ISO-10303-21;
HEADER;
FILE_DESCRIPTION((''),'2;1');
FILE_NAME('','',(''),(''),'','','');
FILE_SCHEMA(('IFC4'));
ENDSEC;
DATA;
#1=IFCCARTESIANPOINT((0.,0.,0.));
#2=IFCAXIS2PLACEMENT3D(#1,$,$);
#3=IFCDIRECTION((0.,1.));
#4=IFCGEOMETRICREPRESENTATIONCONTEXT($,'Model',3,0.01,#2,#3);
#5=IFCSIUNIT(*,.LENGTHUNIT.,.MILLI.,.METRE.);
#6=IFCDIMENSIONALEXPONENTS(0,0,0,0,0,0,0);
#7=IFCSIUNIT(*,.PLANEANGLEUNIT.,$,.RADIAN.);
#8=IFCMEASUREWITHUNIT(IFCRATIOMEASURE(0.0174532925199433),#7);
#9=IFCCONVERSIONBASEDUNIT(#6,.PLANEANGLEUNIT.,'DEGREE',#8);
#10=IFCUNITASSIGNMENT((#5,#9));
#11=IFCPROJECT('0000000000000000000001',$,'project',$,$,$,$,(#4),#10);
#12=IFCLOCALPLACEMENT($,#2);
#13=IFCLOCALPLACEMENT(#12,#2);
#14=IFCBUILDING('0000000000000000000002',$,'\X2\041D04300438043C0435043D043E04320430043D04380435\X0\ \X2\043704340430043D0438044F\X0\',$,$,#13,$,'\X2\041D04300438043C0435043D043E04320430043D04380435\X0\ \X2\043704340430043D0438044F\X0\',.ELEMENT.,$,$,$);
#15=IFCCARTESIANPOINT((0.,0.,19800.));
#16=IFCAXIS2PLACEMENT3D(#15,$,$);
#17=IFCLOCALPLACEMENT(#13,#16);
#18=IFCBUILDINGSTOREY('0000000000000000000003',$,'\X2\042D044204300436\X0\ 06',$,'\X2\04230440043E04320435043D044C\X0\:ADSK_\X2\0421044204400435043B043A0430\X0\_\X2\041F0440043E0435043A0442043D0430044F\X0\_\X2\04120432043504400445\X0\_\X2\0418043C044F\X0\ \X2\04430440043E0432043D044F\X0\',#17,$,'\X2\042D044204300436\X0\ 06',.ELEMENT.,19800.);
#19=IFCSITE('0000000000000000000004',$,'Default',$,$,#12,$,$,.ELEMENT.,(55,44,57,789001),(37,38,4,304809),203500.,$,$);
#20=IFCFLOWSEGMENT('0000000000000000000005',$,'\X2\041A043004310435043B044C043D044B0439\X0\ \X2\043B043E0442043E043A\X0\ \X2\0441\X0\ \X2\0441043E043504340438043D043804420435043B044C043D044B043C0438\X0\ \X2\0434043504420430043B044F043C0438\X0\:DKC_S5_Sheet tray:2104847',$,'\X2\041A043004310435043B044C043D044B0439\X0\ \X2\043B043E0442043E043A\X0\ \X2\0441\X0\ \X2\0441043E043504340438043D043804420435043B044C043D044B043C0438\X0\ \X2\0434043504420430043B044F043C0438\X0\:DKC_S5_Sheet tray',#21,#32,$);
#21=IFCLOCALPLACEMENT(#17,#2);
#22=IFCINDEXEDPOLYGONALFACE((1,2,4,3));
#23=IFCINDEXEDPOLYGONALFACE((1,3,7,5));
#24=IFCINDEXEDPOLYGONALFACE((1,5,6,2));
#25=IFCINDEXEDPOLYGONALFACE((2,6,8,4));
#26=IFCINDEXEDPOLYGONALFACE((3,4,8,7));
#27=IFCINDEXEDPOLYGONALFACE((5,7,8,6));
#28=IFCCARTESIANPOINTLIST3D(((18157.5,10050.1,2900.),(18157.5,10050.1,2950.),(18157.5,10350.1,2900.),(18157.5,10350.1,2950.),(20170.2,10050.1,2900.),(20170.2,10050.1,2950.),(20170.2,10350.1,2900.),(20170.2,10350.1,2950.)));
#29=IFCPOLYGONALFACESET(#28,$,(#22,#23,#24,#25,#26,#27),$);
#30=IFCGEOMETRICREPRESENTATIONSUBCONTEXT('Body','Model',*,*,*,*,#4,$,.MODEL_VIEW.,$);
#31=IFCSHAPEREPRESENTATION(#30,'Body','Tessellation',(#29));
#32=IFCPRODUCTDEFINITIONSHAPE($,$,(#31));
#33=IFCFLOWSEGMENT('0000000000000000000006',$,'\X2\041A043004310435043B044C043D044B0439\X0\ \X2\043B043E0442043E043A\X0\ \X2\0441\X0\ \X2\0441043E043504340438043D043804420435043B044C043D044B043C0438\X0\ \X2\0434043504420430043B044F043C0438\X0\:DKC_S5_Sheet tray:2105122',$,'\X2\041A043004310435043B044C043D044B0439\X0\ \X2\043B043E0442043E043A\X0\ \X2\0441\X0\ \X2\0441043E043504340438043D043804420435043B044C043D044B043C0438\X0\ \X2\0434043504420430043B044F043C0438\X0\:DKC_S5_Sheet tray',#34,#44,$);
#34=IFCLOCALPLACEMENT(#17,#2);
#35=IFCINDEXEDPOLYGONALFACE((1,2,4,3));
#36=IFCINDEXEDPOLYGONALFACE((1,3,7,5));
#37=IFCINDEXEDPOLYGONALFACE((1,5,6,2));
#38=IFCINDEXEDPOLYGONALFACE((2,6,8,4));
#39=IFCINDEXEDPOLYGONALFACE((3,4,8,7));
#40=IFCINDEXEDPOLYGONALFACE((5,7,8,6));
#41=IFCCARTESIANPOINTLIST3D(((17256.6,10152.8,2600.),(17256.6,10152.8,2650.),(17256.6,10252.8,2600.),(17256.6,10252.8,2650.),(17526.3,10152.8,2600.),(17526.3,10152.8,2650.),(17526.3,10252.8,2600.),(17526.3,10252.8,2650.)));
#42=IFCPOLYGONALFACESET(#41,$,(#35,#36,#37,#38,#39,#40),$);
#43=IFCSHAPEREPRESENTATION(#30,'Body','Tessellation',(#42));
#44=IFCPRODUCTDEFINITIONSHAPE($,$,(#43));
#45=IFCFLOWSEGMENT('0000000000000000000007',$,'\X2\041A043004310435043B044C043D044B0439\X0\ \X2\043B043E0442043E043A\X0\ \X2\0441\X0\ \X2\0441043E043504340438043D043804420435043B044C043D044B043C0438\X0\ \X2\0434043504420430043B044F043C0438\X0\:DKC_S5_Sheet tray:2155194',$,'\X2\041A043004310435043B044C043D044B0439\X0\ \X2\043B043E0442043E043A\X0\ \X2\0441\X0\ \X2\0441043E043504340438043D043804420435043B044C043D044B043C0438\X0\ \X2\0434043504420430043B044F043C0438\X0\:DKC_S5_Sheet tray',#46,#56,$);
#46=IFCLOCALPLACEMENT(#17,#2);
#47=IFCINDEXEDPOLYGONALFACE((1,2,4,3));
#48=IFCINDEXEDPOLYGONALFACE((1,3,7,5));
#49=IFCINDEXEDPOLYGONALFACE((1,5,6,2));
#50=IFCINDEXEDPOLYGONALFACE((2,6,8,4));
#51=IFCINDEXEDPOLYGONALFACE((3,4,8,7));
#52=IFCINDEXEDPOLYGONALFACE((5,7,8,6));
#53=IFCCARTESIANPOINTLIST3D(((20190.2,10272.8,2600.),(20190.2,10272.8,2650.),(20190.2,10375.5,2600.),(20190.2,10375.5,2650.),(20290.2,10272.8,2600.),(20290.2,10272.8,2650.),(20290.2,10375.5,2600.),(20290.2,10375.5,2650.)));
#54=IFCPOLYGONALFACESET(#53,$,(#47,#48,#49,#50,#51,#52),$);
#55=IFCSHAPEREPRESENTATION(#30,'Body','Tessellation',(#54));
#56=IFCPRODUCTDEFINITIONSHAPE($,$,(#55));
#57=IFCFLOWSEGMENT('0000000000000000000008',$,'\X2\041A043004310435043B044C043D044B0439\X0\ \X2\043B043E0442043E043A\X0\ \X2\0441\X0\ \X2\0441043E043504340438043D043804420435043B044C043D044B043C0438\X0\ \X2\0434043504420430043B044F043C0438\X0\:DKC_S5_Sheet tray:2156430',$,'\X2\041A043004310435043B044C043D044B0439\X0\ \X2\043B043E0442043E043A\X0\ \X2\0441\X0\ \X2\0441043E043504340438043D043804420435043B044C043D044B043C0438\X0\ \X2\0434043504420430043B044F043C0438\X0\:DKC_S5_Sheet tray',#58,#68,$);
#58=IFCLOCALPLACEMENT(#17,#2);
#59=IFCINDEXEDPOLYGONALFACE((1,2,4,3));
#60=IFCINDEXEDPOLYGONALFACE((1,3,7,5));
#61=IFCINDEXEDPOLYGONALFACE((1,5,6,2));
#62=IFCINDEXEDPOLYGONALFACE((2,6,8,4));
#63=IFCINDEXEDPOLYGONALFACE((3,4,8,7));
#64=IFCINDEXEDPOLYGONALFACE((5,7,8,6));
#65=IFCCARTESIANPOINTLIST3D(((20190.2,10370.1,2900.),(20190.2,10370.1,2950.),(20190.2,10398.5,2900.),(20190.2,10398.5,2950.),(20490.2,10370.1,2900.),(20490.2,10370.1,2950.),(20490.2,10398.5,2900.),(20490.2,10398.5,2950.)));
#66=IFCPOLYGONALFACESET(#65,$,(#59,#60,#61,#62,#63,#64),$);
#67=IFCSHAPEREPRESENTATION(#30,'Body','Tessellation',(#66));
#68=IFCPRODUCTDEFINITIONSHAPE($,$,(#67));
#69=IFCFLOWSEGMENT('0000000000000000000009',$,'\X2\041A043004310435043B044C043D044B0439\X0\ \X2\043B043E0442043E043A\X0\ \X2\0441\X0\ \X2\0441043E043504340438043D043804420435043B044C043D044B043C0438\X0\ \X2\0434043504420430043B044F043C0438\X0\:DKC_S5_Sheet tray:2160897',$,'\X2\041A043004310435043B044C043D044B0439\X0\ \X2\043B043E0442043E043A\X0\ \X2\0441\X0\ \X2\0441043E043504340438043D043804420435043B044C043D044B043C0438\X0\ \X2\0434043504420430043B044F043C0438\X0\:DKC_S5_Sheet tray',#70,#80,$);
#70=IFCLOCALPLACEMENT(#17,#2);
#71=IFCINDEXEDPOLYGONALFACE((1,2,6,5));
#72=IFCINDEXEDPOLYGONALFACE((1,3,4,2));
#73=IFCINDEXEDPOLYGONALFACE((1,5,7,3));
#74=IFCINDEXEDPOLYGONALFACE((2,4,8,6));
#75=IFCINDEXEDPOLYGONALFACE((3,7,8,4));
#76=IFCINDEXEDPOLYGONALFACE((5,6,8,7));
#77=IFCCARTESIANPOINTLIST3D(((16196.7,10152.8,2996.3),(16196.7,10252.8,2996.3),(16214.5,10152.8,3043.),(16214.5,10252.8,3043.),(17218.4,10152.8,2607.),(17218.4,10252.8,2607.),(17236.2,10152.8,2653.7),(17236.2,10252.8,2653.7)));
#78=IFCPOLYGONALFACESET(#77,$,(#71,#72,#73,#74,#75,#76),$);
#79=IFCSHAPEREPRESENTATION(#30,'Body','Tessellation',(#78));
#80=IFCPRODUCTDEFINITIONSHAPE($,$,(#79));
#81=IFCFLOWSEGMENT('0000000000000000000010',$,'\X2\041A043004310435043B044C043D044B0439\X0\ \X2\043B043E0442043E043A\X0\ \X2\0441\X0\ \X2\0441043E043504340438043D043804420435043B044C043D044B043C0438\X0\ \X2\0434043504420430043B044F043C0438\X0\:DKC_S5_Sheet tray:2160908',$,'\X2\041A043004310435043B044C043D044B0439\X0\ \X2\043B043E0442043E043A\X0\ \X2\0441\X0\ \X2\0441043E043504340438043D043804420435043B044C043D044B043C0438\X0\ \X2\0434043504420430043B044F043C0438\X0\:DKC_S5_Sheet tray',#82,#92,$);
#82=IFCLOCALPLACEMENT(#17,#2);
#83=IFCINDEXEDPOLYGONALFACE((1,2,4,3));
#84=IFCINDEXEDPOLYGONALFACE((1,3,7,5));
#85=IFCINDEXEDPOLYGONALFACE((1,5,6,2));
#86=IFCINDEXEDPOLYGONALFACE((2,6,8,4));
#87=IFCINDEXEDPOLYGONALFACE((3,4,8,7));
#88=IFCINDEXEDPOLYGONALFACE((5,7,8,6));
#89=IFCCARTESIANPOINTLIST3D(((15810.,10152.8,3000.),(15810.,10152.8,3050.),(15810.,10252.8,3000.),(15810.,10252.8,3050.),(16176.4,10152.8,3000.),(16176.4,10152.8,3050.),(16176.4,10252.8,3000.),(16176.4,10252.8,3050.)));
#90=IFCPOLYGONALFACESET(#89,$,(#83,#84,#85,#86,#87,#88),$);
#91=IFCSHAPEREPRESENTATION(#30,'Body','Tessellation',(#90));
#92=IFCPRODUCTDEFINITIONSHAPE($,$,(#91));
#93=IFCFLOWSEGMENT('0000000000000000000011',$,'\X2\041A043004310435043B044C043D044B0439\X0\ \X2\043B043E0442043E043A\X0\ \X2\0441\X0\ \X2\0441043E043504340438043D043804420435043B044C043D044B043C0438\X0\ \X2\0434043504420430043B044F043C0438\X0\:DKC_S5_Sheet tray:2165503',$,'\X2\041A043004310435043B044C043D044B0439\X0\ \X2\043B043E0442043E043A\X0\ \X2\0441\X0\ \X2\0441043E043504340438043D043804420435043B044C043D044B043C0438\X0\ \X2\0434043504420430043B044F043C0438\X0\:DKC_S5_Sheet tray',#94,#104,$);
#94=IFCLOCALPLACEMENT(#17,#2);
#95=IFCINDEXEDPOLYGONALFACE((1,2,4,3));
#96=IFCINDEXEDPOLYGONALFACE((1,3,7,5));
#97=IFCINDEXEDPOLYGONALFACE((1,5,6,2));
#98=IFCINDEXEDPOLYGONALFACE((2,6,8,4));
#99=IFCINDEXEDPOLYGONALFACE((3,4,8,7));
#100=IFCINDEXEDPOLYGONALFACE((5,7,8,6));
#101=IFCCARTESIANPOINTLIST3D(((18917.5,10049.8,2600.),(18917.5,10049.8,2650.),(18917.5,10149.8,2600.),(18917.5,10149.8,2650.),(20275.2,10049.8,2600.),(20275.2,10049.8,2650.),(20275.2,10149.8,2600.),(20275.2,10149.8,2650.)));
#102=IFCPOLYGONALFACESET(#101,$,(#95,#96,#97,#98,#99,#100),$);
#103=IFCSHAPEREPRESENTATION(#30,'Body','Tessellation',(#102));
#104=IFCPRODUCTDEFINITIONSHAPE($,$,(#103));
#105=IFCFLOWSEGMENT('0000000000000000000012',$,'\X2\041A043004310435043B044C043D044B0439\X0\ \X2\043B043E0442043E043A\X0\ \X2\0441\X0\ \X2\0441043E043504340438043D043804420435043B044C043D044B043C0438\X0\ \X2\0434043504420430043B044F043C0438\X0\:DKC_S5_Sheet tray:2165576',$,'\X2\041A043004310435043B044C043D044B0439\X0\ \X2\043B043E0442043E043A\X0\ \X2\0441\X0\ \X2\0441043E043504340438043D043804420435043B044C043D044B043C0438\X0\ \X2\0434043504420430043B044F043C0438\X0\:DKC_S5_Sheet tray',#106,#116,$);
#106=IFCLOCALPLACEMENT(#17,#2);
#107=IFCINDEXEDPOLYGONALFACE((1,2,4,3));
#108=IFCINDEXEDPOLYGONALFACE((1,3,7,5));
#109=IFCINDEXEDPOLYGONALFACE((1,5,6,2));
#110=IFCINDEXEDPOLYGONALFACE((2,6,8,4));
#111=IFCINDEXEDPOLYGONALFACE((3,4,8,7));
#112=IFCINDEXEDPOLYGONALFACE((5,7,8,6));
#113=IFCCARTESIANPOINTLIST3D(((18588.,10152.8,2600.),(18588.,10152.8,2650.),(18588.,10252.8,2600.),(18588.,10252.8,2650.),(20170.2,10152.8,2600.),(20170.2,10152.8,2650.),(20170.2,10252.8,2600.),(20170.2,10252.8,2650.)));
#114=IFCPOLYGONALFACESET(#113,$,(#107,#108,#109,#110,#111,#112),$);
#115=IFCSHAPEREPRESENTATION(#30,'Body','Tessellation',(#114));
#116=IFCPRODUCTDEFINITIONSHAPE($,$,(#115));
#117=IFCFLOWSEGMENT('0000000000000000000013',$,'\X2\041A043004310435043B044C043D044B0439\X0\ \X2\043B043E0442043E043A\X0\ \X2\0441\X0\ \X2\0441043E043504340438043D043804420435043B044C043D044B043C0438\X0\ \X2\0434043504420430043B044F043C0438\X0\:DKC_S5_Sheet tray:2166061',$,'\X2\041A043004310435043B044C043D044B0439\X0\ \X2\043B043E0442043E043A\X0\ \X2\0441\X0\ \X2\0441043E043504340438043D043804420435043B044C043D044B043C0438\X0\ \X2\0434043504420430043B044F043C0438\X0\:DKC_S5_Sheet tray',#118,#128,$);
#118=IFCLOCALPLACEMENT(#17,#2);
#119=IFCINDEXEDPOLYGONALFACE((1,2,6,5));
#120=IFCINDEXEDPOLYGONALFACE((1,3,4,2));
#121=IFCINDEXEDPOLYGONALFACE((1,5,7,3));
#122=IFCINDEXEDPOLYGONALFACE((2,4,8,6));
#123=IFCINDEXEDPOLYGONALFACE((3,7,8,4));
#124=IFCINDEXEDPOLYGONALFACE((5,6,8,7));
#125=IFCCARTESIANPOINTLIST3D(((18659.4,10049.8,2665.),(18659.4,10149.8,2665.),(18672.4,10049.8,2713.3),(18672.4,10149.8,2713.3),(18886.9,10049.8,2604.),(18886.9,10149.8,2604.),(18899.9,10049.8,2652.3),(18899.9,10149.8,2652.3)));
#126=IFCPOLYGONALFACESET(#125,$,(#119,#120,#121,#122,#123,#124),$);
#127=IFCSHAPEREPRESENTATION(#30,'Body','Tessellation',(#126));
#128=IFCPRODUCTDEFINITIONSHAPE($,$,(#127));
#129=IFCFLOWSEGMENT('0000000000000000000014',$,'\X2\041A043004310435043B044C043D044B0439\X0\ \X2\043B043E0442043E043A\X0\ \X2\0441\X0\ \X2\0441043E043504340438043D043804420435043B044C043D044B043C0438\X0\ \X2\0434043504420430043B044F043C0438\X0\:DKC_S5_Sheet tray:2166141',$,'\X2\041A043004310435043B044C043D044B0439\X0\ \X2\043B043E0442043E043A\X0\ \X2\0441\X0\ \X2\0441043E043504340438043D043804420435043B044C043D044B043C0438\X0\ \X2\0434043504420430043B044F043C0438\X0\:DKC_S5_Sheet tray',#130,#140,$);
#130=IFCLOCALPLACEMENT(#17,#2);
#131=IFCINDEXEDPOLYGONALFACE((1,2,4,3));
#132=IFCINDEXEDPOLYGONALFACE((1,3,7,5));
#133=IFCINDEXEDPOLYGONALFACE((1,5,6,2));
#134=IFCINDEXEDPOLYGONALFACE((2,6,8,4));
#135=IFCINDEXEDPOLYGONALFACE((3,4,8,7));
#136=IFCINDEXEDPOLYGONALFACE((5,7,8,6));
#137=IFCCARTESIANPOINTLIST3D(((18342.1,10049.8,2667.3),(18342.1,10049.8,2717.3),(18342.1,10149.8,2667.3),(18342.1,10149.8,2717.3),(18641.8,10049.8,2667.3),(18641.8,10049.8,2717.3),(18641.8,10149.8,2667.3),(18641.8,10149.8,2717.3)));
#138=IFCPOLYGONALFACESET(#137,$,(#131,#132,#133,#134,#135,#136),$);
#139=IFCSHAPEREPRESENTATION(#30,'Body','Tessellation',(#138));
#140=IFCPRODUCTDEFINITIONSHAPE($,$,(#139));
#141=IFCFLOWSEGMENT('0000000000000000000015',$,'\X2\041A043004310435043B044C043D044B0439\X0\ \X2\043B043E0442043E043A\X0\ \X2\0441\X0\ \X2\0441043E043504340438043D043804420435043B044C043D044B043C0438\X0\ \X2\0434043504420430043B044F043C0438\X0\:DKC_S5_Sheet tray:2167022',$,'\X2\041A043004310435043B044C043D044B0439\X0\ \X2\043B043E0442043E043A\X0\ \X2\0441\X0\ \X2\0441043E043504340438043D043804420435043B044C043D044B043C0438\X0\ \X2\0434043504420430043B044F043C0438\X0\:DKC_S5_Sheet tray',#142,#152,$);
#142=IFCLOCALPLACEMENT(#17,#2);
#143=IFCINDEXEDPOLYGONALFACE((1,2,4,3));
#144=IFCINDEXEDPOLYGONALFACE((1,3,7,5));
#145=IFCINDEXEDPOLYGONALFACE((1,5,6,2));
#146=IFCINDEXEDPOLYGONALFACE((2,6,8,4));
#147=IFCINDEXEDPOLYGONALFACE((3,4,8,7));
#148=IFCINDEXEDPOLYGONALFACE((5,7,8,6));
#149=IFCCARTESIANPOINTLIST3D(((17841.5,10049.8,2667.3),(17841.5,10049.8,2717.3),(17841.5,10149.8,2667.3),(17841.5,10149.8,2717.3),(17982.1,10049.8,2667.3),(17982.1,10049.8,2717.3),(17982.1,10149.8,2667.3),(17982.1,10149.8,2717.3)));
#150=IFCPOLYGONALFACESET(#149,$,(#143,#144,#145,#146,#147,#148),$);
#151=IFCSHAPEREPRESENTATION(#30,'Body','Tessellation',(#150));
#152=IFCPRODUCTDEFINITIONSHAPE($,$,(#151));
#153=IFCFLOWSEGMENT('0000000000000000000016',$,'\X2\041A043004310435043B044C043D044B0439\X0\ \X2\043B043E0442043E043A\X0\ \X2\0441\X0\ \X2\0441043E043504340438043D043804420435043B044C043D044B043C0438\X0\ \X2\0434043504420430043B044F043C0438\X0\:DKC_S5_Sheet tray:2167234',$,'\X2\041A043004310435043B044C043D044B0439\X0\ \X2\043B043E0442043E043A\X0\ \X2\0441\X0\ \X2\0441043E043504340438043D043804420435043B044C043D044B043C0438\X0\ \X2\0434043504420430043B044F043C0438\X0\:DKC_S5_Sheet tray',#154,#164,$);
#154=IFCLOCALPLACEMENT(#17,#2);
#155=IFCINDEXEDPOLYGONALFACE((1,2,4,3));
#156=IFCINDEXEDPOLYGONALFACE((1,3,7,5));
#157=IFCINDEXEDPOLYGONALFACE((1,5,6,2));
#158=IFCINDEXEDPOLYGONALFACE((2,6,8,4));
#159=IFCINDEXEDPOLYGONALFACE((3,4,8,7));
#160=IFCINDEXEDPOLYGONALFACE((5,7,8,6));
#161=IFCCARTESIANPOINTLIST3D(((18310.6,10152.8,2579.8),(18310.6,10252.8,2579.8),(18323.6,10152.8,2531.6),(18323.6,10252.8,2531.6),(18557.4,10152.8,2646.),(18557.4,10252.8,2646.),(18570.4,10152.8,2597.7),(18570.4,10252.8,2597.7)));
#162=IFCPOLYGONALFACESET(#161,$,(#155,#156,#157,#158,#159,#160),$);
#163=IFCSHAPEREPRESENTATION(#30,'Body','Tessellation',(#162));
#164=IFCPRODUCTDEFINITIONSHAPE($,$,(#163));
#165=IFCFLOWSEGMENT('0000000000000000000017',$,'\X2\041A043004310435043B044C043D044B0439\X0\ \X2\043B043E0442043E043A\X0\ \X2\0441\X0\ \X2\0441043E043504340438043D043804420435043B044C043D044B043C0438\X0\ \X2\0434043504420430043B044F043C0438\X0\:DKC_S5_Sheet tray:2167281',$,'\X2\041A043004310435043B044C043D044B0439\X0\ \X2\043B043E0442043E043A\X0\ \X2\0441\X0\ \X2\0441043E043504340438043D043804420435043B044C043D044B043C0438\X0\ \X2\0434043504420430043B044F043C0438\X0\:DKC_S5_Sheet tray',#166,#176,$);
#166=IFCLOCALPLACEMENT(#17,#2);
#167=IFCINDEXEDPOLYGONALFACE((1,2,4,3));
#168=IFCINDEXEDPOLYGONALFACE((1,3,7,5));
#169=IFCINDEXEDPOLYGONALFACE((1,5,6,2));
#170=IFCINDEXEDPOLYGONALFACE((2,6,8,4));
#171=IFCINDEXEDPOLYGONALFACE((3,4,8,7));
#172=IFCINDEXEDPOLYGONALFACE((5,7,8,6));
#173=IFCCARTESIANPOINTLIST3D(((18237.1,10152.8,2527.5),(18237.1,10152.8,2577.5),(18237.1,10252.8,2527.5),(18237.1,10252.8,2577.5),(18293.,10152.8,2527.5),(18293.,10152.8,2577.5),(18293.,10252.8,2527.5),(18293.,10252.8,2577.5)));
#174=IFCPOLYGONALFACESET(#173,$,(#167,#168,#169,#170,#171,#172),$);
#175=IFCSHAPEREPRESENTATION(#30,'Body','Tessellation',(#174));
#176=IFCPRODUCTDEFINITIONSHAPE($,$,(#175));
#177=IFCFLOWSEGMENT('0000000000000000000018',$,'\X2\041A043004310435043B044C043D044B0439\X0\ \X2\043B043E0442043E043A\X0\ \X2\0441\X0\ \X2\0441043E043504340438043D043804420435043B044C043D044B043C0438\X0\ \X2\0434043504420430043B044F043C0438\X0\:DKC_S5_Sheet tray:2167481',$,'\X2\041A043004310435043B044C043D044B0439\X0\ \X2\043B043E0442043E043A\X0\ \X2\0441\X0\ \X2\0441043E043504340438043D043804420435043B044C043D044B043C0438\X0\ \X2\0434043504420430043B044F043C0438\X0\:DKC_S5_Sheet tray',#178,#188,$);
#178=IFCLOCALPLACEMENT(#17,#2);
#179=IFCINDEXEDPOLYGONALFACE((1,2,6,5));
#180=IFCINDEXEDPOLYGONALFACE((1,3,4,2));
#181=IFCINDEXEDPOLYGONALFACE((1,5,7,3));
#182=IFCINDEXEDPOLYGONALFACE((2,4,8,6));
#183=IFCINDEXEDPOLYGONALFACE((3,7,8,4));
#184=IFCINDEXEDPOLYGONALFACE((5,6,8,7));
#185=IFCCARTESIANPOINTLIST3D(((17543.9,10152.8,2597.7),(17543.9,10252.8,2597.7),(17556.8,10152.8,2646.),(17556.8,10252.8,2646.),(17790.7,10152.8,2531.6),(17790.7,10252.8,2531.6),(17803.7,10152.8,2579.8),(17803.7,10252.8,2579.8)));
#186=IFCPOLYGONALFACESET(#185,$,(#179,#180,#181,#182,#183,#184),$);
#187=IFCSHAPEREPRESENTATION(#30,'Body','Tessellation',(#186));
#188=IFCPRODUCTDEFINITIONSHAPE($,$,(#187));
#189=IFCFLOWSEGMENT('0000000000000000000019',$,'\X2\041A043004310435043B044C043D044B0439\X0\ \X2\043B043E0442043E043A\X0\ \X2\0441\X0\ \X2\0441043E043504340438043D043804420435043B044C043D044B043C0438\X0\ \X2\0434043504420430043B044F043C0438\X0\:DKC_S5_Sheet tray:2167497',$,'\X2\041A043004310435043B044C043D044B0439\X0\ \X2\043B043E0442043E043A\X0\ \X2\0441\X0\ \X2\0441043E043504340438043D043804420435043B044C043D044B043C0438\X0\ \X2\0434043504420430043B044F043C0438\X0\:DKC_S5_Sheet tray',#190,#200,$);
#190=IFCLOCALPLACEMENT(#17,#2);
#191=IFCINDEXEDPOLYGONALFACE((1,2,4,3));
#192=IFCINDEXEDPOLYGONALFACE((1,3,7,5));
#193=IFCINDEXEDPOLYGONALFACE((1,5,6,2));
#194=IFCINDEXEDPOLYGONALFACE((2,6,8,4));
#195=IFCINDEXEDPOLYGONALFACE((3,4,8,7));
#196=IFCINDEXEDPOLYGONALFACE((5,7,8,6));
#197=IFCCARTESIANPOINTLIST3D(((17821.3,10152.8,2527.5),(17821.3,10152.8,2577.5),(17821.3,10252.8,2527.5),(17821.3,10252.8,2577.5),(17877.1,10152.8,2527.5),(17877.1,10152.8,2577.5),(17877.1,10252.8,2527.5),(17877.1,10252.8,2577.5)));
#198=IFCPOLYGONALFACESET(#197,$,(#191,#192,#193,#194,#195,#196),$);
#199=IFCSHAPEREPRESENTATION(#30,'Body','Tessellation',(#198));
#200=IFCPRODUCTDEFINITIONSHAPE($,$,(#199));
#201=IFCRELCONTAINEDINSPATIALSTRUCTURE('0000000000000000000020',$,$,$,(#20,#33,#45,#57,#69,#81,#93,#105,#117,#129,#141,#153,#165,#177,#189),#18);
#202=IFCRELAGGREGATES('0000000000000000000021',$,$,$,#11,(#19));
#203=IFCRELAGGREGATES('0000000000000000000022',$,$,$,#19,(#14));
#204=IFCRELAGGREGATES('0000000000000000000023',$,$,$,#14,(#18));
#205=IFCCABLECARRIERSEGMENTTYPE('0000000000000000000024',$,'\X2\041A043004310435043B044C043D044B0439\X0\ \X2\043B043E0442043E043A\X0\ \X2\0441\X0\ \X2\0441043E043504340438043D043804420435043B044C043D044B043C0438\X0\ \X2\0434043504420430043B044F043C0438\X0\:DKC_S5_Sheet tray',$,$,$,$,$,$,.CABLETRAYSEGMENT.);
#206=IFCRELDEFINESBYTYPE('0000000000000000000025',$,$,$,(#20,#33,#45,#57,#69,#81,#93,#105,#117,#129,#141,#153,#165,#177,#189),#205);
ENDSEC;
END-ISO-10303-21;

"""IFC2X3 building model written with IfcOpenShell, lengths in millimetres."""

from ifc_helpers import new_model, entity, si_unit, converted_unit, direction, frame, frame_2d, origin, origin_2d_with_axis, place, context, subcontext, project, spatial, rectangle, extrude, type_object, element, save


model = new_model("IFC2X3")

# Units and contexts
model_context = context("Model", 3, precision=0.01, world=origin(), true_north=direction((0.0, 1.0)))
body_context = subcontext(model_context, "Body", "Model", "MODEL_VIEW")
ifc_project = project(units=[si_unit("LENGTHUNIT", "METRE", prefix="MILLI"), converted_unit("PLANEANGLEUNIT", "DEGREE", entity("IfcRatioMeasure", 0.0174532925199433), si_unit("PLANEANGLEUNIT", "RADIAN"), dimensions=[0, 0, 0, 0, 0, 0, 0])], contexts=[model_context])

# Site, building, storey
site_placement = place(None, frame((0.0, 0.0, 0.0)))
site = spatial("IfcSite", under=ifc_project, at=site_placement, Name="Default", CompositionType="ELEMENT", RefLatitude=(55, 44, 57, 789001), RefLongitude=(37, 38, 4, 304809), RefElevation=203500.0)
building_placement = place(site_placement, origin())
building = spatial("IfcBuilding", under=site, at=building_placement, Name="Наименование здания", LongName="Наименование здания", CompositionType="ELEMENT")
storey_placement = place(building_placement, frame((0.0, 0.0, 19800.0)))
storey = spatial("IfcBuildingStorey", under=building, at=storey_placement, Name="Этаж 06", ObjectType="Уровень:ADSK_Стрелка_Проектная_Вверх_Имя уровня", LongName="Этаж 06", CompositionType="ELEMENT", Elevation=19800.0)

# Flow segments
cable_carrier_segment_type_1 = type_object("IfcCableCarrierSegmentType", Name="Кабельный лоток с соединительными деталями:DKC_S5_Sheet tray", PredefinedType="CABLETRAYSEGMENT")
flow_segment_1_placement = place(storey_placement, frame((18157.5, 10050.1, 2900.0)))
element("IfcFlowSegment", 1, at=flow_segment_1_placement, inside=storey, type_object=cable_carrier_segment_type_1, Name="Кабельный лоток с соединительными деталями:DKC_S5_Sheet tray:2104847", ObjectType="Кабельный лоток с соединительными деталями:DKC_S5_Sheet tray", context=body_context, shape_type="SweptSolid", body=[
    extrude(rectangle(XDim=2012.7, YDim=300.0, at=frame_2d((0.0, 0.0), x_axis=(1.0, 0.0))), frame((1006.3, 150.0, 0.0), z_axis=(0.0, 0.0, 1.0), x_axis=(-1.0, 0.0, 0.0)), (0.0, 0.0, 1.0), 50.0),
])
flow_segment_2_placement = place(storey_placement, frame((17256.6, 10152.8, 2600.0)))
element("IfcFlowSegment", 2, at=flow_segment_2_placement, inside=storey, type_object=cable_carrier_segment_type_1, Name="Кабельный лоток с соединительными деталями:DKC_S5_Sheet tray:2105122", ObjectType="Кабельный лоток с соединительными деталями:DKC_S5_Sheet tray", context=body_context, shape_type="SweptSolid", body=[
    extrude(rectangle(XDim=269.7, YDim=100.0, at=frame_2d((0.0, 0.0), x_axis=(1.0, 0.0))), frame((134.9, 50.0, 0.0)), (0.0, 0.0, 1.0), 50.0),
])
flow_segment_3_placement = place(storey_placement, frame((20190.2, 10272.8, 2600.0)))
element("IfcFlowSegment", 3, at=flow_segment_3_placement, inside=storey, type_object=cable_carrier_segment_type_1, Name="Кабельный лоток с соединительными деталями:DKC_S5_Sheet tray:2155194", ObjectType="Кабельный лоток с соединительными деталями:DKC_S5_Sheet tray", context=body_context, shape_type="SweptSolid", body=[
    extrude(rectangle(XDim=102.6, YDim=100.0, at=origin_2d_with_axis()), frame((50.0, 51.3, 0.0), z_axis=(0.0, 0.0, 1.0), x_axis=(0.0, 1.0, 0.0)), (0.0, 0.0, 1.0), 50.0),
])
flow_segment_4_placement = place(storey_placement, frame((20190.2, 10370.1, 2900.0)))
element("IfcFlowSegment", 4, at=flow_segment_4_placement, inside=storey, type_object=cable_carrier_segment_type_1, Name="Кабельный лоток с соединительными деталями:DKC_S5_Sheet tray:2156430", ObjectType="Кабельный лоток с соединительными деталями:DKC_S5_Sheet tray", context=body_context, shape_type="SweptSolid", body=[
    extrude(rectangle(XDim=28.4, YDim=300.0, at=frame_2d((0.0, 0.0), x_axis=(1.0, 0.0))), frame((150.0, 14.2, 0.0), z_axis=(0.0, 0.0, 1.0), x_axis=(0.0, -1.0, 0.0)), (0.0, 0.0, 1.0), 50.0),
])
flow_segment_5_placement = place(storey_placement, frame((16196.7, 10152.8, 2607.0)))
element("IfcFlowSegment", 5, at=flow_segment_5_placement, inside=storey, type_object=cable_carrier_segment_type_1, Name="Кабельный лоток с соединительными деталями:DKC_S5_Sheet tray:2160897", ObjectType="Кабельный лоток с соединительными деталями:DKC_S5_Sheet tray", context=body_context, shape_type="SweptSolid", body=[
    extrude(rectangle(XDim=50.0, YDim=100.0, at=frame_2d((0.0, 0.0), x_axis=(1.0, 0.0))), frame((8.9, 50.0, 412.6), z_axis=(0.934483, 0.0, -0.356007), x_axis=(0.356007, 0.0, 0.934483)), (0.0, 0.0, 1.0), 1093.3),
])
flow_segment_6_placement = place(storey_placement, frame((15810.0, 10152.8, 3000.0)))
element("IfcFlowSegment", 6, at=flow_segment_6_placement, inside=storey, type_object=cable_carrier_segment_type_1, Name="Кабельный лоток с соединительными деталями:DKC_S5_Sheet tray:2160908", ObjectType="Кабельный лоток с соединительными деталями:DKC_S5_Sheet tray", context=body_context, shape_type="SweptSolid", body=[
    extrude(rectangle(XDim=366.4, YDim=100.0, at=frame_2d((0.0, 0.0), x_axis=(1.0, 0.0))), frame((183.2, 50.0, 0.0), z_axis=(0.0, 0.0, 1.0), x_axis=(-1.0, 0.0, 0.0)), (0.0, 0.0, 1.0), 50.0),
])
flow_segment_7_placement = place(storey_placement, frame((18917.5, 10049.8, 2600.0)))
element("IfcFlowSegment", 7, at=flow_segment_7_placement, inside=storey, type_object=cable_carrier_segment_type_1, Name="Кабельный лоток с соединительными деталями:DKC_S5_Sheet tray:2165503", ObjectType="Кабельный лоток с соединительными деталями:DKC_S5_Sheet tray", context=body_context, shape_type="SweptSolid", body=[
    extrude(rectangle(XDim=1357.8, YDim=100.0, at=frame_2d((0.0, 0.0), x_axis=(1.0, 0.0))), frame((678.9, 50.0, 0.0), z_axis=(0.0, 0.0, 1.0), x_axis=(-1.0, 0.0, 0.0)), (0.0, 0.0, 1.0), 50.0),
])
flow_segment_8_placement = place(storey_placement, frame((18588.0, 10152.8, 2600.0)))
element("IfcFlowSegment", 8, at=flow_segment_8_placement, inside=storey, type_object=cable_carrier_segment_type_1, Name="Кабельный лоток с соединительными деталями:DKC_S5_Sheet tray:2165576", ObjectType="Кабельный лоток с соединительными деталями:DKC_S5_Sheet tray", context=body_context, shape_type="SweptSolid", body=[
    extrude(rectangle(XDim=1582.2, YDim=100.0, at=frame_2d((0.0, 0.0), x_axis=(1.0, 0.0))), frame((791.1, 50.0, 0.0), z_axis=(0.0, 0.0, 1.0), x_axis=(-1.0, 0.0, 0.0)), (0.0, 0.0, 1.0), 50.0),
])
flow_segment_9_placement = place(storey_placement, frame((18659.4, 10049.8, 2604.0)))
element("IfcFlowSegment", 9, at=flow_segment_9_placement, inside=storey, type_object=cable_carrier_segment_type_1, Name="Кабельный лоток с соединительными деталями:DKC_S5_Sheet tray:2166061", ObjectType="Кабельный лоток с соединительными деталями:DKC_S5_Sheet tray", context=body_context, shape_type="SweptSolid", body=[
    extrude(rectangle(XDim=50.0, YDim=100.0, at=origin_2d_with_axis()), frame((6.5, 50.0, 85.1), z_axis=(0.965926, 0.0, -0.258819), x_axis=(0.258819, 0.0, 0.965926)), (0.0, 0.0, 1.0), 235.5),
])
flow_segment_10_placement = place(storey_placement, frame((18342.1, 10049.8, 2667.3)))
element("IfcFlowSegment", 10, at=flow_segment_10_placement, inside=storey, type_object=cable_carrier_segment_type_1, Name="Кабельный лоток с соединительными деталями:DKC_S5_Sheet tray:2166141", ObjectType="Кабельный лоток с соединительными деталями:DKC_S5_Sheet tray", context=body_context, shape_type="SweptSolid", body=[
    extrude(rectangle(XDim=299.7, YDim=100.0, at=frame_2d((0.0, 0.0), x_axis=(1.0, 0.0))), frame((149.8, 50.0, 0.0), z_axis=(0.0, 0.0, 1.0), x_axis=(-1.0, 0.0, 0.0)), (0.0, 0.0, 1.0), 50.0),
])
flow_segment_11_placement = place(storey_placement, frame((17841.5, 10049.8, 2667.3)))
element("IfcFlowSegment", 11, at=flow_segment_11_placement, inside=storey, type_object=cable_carrier_segment_type_1, Name="Кабельный лоток с соединительными деталями:DKC_S5_Sheet tray:2167022", ObjectType="Кабельный лоток с соединительными деталями:DKC_S5_Sheet tray", context=body_context, shape_type="SweptSolid", body=[
    extrude(rectangle(XDim=140.7, YDim=100.0, at=frame_2d((0.0, 0.0), x_axis=(1.0, 0.0))), frame((70.3, 50.0, 0.0), z_axis=(0.0, 0.0, 1.0), x_axis=(-1.0, 0.0, 0.0)), (0.0, 0.0, 1.0), 50.0),
])
flow_segment_12_placement = place(storey_placement, frame((18310.6, 10152.8, 2531.6)))
element("IfcFlowSegment", 12, at=flow_segment_12_placement, inside=storey, type_object=cable_carrier_segment_type_1, Name="Кабельный лоток с соединительными деталями:DKC_S5_Sheet tray:2167234", ObjectType="Кабельный лоток с соединительными деталями:DKC_S5_Sheet tray", context=body_context, shape_type="SweptSolid", body=[
    extrude(rectangle(XDim=50.0, YDim=100.0, at=frame_2d((0.0, 0.0), x_axis=(1.0, 0.0))), frame((6.5, 50.0, 24.1), z_axis=(0.965926, 0.0, 0.258819), x_axis=(-0.258819, 0.0, 0.965926)), (0.0, 0.0, 1.0), 255.5),
])
flow_segment_13_placement = place(storey_placement, frame((18237.1, 10152.8, 2527.5)))
element("IfcFlowSegment", 13, at=flow_segment_13_placement, inside=storey, type_object=cable_carrier_segment_type_1, Name="Кабельный лоток с соединительными деталями:DKC_S5_Sheet tray:2167281", ObjectType="Кабельный лоток с соединительными деталями:DKC_S5_Sheet tray", context=body_context, shape_type="SweptSolid", body=[
    extrude(rectangle(XDim=55.9, YDim=100.0, at=frame_2d((0.0, 0.0), x_axis=(1.0, 0.0))), frame((27.9, 50.0, 0.0), z_axis=(0.0, 0.0, 1.0), x_axis=(-1.0, 0.0, 0.0)), (0.0, 0.0, 1.0), 50.0),
])
flow_segment_14_placement = place(storey_placement, frame((17543.9, 10152.8, 2531.6)))
element("IfcFlowSegment", 14, at=flow_segment_14_placement, inside=storey, type_object=cable_carrier_segment_type_1, Name="Кабельный лоток с соединительными деталями:DKC_S5_Sheet tray:2167481", ObjectType="Кабельный лоток с соединительными деталями:DKC_S5_Sheet tray", context=body_context, shape_type="SweptSolid", body=[
    extrude(rectangle(XDim=50.0, YDim=100.0, at=frame_2d((0.0, 0.0), x_axis=(0.0, 1.0))), frame((6.5, 50.0, 90.3), z_axis=(0.965926, 0.0, -0.258819), x_axis=(0.0, 1.0, 0.0)), (0.0, 0.0, 1.0), 255.5),
])
flow_segment_15_placement = place(storey_placement, frame((17821.3, 10152.8, 2527.5)))
element("IfcFlowSegment", 15, at=flow_segment_15_placement, inside=storey, type_object=cable_carrier_segment_type_1, Name="Кабельный лоток с соединительными деталями:DKC_S5_Sheet tray:2167497", ObjectType="Кабельный лоток с соединительными деталями:DKC_S5_Sheet tray", context=body_context, shape_type="SweptSolid", body=[
    extrude(rectangle(XDim=55.9, YDim=100.0, at=frame_2d((0.0, 0.0), x_axis=(1.0, 0.0))), frame((27.9, 50.0, 0.0)), (0.0, 0.0, 1.0), 50.0),
])

save(model, "model.ifc")
